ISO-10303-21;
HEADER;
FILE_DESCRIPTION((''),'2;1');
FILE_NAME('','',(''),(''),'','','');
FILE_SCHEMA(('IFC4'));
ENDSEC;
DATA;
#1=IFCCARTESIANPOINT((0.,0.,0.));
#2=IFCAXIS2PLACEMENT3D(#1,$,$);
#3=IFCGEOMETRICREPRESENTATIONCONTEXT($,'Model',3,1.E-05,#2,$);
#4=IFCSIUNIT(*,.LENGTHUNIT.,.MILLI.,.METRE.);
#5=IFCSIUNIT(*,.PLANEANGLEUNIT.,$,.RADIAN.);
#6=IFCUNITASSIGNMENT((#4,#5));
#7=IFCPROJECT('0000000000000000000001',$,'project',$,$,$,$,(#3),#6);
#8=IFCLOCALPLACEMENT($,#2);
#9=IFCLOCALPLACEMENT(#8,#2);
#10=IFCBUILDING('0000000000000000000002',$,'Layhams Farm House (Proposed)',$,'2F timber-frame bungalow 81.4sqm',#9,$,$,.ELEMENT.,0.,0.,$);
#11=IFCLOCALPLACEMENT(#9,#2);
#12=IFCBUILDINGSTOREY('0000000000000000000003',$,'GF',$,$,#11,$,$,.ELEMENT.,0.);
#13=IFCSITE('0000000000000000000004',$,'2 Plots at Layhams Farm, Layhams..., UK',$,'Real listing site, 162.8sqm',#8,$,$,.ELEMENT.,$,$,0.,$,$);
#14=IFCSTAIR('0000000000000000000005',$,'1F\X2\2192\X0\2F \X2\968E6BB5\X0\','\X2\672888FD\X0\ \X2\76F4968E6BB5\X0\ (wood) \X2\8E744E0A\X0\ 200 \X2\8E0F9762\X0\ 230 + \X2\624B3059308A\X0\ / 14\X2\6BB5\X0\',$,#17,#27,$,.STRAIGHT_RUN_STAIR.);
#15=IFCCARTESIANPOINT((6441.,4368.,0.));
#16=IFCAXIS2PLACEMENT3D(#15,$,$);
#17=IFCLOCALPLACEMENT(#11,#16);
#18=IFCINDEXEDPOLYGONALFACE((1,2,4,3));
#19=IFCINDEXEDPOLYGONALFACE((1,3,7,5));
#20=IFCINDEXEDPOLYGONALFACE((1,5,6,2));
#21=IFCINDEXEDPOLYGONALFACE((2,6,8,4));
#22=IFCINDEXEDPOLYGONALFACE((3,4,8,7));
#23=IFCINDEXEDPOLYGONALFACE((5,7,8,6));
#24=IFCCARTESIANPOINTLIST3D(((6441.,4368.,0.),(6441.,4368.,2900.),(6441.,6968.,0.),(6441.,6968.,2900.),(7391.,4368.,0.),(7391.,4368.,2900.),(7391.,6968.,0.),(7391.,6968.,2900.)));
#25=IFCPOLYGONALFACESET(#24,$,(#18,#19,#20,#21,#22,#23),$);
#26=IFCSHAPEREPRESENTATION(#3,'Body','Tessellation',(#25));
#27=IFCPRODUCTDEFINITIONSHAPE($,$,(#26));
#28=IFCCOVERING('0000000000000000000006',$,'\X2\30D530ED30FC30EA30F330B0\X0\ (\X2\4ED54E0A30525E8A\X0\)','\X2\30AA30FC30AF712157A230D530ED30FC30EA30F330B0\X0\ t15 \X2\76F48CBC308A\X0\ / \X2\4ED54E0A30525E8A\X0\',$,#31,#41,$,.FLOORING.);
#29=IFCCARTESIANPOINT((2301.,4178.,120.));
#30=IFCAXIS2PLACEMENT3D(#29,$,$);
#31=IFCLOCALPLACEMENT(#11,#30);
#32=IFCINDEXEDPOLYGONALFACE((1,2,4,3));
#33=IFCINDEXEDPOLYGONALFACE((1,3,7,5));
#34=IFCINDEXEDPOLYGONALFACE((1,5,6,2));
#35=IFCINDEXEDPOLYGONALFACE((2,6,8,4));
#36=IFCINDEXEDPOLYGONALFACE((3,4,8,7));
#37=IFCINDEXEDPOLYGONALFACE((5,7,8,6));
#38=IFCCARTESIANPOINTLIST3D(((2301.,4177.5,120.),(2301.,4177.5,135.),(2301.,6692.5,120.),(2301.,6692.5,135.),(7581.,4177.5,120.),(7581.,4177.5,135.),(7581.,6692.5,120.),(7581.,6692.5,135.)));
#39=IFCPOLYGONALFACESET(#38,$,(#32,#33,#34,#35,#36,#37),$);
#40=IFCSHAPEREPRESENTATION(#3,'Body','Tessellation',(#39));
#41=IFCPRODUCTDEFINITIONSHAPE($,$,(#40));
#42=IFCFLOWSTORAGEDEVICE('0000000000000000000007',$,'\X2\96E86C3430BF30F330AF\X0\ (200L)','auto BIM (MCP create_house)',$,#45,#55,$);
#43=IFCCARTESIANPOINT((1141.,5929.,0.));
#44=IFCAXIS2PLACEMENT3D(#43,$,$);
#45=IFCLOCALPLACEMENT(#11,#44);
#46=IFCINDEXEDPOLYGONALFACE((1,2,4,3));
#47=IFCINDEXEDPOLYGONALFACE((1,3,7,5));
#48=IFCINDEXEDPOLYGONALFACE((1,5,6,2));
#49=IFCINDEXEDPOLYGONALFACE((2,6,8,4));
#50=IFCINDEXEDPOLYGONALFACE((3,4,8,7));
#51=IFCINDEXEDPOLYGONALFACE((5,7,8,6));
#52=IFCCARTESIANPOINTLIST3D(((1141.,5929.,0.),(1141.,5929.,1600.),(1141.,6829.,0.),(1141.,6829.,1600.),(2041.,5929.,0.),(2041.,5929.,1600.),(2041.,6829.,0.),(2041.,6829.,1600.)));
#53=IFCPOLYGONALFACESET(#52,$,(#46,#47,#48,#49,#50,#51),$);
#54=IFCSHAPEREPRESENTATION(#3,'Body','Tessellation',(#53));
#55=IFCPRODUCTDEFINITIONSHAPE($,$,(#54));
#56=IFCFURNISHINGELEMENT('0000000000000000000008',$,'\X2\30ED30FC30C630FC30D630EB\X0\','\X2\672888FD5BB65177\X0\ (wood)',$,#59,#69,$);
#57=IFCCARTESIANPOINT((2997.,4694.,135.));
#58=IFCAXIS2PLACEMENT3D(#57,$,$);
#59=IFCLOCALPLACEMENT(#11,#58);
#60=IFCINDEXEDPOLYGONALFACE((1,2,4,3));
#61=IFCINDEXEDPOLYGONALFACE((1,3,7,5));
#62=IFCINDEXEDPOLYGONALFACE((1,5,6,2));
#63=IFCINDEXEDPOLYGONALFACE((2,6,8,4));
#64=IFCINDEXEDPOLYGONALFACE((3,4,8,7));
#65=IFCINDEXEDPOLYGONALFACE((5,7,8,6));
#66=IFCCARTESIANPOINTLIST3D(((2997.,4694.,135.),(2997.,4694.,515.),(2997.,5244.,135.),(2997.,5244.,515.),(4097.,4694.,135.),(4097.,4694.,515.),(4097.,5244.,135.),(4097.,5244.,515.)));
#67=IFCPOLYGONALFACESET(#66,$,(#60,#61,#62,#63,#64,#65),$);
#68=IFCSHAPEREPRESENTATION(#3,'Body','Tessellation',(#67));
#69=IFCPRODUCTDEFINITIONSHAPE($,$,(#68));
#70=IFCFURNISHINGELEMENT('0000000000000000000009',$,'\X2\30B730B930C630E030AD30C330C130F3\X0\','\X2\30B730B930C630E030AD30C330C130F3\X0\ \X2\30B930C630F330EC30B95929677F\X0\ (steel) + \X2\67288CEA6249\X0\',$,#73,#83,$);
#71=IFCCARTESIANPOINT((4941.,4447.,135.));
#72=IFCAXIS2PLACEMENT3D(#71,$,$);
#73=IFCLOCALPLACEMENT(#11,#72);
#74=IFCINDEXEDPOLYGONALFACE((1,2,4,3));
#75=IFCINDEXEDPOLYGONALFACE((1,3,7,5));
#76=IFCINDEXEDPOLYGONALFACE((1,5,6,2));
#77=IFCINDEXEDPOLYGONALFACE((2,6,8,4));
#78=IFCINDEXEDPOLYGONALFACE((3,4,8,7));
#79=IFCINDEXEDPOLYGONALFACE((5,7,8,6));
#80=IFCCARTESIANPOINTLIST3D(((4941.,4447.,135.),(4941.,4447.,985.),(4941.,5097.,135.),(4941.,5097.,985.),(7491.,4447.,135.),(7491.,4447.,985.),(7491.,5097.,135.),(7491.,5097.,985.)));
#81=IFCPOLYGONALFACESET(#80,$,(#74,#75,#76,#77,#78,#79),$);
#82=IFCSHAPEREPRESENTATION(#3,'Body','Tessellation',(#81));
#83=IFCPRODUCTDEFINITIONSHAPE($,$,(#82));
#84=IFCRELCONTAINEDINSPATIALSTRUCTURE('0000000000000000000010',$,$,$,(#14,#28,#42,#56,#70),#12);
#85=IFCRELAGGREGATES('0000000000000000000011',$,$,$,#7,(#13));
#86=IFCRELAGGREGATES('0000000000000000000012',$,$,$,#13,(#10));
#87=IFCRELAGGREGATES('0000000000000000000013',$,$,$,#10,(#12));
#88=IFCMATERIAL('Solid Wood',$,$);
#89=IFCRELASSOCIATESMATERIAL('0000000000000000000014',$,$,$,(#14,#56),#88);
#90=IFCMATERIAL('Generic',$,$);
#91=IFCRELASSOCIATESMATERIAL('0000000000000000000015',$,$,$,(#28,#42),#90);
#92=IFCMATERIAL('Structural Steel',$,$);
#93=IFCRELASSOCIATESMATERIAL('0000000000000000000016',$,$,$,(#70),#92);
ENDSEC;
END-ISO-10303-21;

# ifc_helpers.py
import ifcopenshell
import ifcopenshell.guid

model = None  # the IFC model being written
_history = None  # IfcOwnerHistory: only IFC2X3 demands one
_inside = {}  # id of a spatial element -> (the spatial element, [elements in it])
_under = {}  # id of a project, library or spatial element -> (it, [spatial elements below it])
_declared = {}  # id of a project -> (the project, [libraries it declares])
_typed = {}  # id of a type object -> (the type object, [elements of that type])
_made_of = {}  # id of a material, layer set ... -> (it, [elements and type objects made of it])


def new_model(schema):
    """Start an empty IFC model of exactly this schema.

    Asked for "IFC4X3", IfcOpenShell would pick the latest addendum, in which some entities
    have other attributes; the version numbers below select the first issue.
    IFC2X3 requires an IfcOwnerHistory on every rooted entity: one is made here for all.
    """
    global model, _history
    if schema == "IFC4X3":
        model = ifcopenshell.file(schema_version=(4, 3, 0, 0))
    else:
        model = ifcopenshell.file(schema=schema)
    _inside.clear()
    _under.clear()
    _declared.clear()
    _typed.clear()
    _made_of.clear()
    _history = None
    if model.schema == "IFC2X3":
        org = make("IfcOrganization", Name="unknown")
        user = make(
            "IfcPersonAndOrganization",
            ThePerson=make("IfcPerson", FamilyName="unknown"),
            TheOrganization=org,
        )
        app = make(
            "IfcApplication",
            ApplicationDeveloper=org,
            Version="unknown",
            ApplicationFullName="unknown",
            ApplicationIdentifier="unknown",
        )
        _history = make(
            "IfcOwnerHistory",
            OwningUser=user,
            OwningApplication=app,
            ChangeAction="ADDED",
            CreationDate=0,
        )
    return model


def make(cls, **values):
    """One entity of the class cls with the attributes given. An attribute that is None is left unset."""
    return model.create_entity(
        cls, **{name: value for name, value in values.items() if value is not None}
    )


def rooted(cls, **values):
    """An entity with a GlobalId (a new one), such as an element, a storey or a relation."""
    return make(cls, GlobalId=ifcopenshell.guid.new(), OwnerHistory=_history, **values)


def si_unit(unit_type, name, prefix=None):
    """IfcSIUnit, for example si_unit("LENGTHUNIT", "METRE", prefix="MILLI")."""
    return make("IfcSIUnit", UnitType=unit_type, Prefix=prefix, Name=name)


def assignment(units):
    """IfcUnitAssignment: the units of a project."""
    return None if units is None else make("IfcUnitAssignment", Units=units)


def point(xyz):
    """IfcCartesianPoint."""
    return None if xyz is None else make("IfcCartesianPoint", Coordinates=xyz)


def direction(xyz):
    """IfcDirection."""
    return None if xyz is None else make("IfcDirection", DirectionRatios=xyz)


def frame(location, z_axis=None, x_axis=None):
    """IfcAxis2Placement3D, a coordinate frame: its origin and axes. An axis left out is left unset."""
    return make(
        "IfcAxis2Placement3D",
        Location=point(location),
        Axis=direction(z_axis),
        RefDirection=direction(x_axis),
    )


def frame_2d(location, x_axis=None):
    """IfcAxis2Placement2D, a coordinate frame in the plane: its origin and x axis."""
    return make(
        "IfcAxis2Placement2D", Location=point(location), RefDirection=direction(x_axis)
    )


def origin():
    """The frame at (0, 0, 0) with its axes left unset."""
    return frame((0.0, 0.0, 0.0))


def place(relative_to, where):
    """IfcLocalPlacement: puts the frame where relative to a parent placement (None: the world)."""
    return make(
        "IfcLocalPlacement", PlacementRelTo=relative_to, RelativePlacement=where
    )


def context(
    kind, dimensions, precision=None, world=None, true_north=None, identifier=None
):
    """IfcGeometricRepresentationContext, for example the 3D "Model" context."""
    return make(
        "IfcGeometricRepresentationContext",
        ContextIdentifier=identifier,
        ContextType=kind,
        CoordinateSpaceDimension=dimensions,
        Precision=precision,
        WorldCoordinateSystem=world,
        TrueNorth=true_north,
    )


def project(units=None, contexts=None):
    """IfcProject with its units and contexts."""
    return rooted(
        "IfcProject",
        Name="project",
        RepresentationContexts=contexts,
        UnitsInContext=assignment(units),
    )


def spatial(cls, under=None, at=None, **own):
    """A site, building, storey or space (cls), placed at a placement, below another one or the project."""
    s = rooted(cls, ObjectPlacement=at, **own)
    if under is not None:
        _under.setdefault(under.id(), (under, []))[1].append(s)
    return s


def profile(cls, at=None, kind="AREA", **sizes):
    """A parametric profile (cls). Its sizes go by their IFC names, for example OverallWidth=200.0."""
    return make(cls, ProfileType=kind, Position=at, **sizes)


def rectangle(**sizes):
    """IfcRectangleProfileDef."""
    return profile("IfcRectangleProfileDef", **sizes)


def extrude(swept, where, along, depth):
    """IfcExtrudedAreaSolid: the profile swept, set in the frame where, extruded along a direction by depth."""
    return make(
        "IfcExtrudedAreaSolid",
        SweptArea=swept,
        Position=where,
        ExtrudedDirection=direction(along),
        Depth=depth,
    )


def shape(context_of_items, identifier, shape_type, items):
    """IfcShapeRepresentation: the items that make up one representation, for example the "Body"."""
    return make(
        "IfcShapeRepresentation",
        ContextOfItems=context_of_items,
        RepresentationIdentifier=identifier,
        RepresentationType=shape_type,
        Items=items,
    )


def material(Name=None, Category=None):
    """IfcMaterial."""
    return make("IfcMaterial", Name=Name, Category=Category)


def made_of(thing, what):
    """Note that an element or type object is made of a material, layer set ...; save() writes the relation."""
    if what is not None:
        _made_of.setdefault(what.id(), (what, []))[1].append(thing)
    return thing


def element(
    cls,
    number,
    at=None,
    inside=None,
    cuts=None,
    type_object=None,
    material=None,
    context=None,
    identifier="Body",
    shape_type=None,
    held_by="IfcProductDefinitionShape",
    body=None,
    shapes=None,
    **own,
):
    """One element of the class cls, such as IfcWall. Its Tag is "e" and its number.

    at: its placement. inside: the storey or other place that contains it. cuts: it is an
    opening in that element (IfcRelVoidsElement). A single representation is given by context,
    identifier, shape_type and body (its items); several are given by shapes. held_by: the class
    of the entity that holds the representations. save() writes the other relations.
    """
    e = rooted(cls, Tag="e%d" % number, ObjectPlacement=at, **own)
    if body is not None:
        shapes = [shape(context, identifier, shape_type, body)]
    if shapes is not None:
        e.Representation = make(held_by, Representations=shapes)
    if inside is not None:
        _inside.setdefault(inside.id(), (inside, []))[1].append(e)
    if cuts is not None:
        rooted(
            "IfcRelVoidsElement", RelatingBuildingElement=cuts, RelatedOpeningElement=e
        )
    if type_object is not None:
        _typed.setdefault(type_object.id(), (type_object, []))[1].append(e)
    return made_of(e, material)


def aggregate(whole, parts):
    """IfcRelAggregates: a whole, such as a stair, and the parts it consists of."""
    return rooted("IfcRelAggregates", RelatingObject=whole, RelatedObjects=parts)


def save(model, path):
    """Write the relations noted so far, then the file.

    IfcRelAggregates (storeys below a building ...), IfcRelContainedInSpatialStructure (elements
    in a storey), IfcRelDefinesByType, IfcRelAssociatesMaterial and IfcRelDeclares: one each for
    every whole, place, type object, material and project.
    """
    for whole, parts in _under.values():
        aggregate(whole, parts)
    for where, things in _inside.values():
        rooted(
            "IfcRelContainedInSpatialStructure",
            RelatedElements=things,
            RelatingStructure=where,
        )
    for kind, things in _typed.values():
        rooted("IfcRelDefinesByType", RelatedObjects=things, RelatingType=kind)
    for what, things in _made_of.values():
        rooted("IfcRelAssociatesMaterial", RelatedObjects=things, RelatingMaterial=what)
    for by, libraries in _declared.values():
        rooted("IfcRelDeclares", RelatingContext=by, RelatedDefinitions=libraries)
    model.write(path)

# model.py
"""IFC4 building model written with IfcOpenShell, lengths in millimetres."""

from ifc_helpers import new_model, si_unit, frame, frame_2d, origin, place, context, project, spatial, rectangle, extrude, material, element, save


model = new_model("IFC4")

# Units and contexts
model_context = context("Model", 3, precision=1e-05, world=origin())
ifc_project = project(units=[si_unit("LENGTHUNIT", "METRE", prefix="MILLI"), si_unit("PLANEANGLEUNIT", "RADIAN")], contexts=[model_context])

# Site, building, storey
site_placement = place(None, origin())
site = spatial("IfcSite", under=ifc_project, at=site_placement, Name="2 Plots at Layhams Farm, Layhams..., UK", ObjectType="Real listing site, 162.8sqm", CompositionType="ELEMENT", RefElevation=0.0)
building_placement = place(site_placement, origin())
building = spatial("IfcBuilding", under=site, at=building_placement, Name="Layhams Farm House (Proposed)", ObjectType="2F timber-frame bungalow 81.4sqm", CompositionType="ELEMENT", ElevationOfRefHeight=0.0, ElevationOfTerrain=0.0)
storey_placement = place(building_placement, origin())
storey = spatial("IfcBuildingStorey", under=building, at=storey_placement, Name="GF", CompositionType="ELEMENT", Elevation=0.0)

# Shared definitions
ifc_material_1 = material(Name="Solid Wood")

# Stair
stair_placement = place(storey_placement, frame((6441.0, 4368.0, 0.0)))
element("IfcStair", 1, at=stair_placement, inside=storey, material=ifc_material_1, Name="1F→2F 階段", Description="木製 直階段 (wood) 蹴上 200 踏面 230 + 手すり / 14段", PredefinedType="STRAIGHT_RUN_STAIR", context=model_context, shape_type="SweptSolid", body=[
    extrude(rectangle(XDim=950.0, YDim=2600.0, at=frame_2d((475.0, 1300.0))), frame((6441.0, 4368.0, 0.0)), (0.0, 0.0, 1.0), 2900.0),
])

# Covering
ifc_material_2 = material(Name="Generic")
covering_placement = place(storey_placement, frame((2301.0, 4178.0, 120.0)))
element("IfcCovering", 2, at=covering_placement, inside=storey, material=ifc_material_2, Name="フローリング (仕上げ床)", Description="オーク無垢フローリング t15 直貼り / 仕上げ床", PredefinedType="FLOORING", context=model_context, shape_type="SweptSolid", body=[
    extrude(rectangle(XDim=5280.0, YDim=2515.0, at=frame_2d((2640.0, 1257.0))), frame((2301.0, 4178.0, 120.0)), (0.0, 0.0, 1.0), 15.0),
])

# Flow storage device
flow_storage_device_placement = place(storey_placement, frame((1141.0, 5929.0, 0.0)))
element("IfcFlowStorageDevice", 3, at=flow_storage_device_placement, inside=storey, material=ifc_material_2, Name="雨水タンク (200L)", Description="auto BIM (MCP create_house)", context=model_context, shape_type="SweptSolid", body=[
    extrude(rectangle(XDim=900.0, YDim=900.0, at=frame_2d((450.0, 450.0))), frame((1141.0, 5929.0, 0.0)), (0.0, 0.0, 1.0), 1600.0),
])

# Furnishing elements
furnishing_1_placement = place(storey_placement, frame((2997.0, 4694.0, 135.0)))
element("IfcFurnishingElement", 4, at=furnishing_1_placement, inside=storey, material=ifc_material_1, Name="ローテーブル", Description="木製家具 (wood)", context=model_context, shape_type="SweptSolid", body=[
    extrude(rectangle(XDim=1100.0, YDim=550.0, at=frame_2d((550.0, 275.0))), frame((2997.0, 4694.0, 135.0)), (0.0, 0.0, 1.0), 380.0),
])
ifc_material_3 = material(Name="Structural Steel")
furnishing_2_placement = place(storey_placement, frame((4941.0, 4447.0, 135.0)))
element("IfcFurnishingElement", 5, at=furnishing_2_placement, inside=storey, material=ifc_material_3, Name="システムキッチン", Description="システムキッチン ステンレス天板 (steel) + 木質扉", context=model_context, shape_type="SweptSolid", body=[
    extrude(rectangle(XDim=2550.0, YDim=650.0, at=frame_2d((1275.0, 325.0))), frame((4941.0, 4447.0, 135.0)), (0.0, 0.0, 1.0), 850.0),
])

save(model, "model.ifc")
